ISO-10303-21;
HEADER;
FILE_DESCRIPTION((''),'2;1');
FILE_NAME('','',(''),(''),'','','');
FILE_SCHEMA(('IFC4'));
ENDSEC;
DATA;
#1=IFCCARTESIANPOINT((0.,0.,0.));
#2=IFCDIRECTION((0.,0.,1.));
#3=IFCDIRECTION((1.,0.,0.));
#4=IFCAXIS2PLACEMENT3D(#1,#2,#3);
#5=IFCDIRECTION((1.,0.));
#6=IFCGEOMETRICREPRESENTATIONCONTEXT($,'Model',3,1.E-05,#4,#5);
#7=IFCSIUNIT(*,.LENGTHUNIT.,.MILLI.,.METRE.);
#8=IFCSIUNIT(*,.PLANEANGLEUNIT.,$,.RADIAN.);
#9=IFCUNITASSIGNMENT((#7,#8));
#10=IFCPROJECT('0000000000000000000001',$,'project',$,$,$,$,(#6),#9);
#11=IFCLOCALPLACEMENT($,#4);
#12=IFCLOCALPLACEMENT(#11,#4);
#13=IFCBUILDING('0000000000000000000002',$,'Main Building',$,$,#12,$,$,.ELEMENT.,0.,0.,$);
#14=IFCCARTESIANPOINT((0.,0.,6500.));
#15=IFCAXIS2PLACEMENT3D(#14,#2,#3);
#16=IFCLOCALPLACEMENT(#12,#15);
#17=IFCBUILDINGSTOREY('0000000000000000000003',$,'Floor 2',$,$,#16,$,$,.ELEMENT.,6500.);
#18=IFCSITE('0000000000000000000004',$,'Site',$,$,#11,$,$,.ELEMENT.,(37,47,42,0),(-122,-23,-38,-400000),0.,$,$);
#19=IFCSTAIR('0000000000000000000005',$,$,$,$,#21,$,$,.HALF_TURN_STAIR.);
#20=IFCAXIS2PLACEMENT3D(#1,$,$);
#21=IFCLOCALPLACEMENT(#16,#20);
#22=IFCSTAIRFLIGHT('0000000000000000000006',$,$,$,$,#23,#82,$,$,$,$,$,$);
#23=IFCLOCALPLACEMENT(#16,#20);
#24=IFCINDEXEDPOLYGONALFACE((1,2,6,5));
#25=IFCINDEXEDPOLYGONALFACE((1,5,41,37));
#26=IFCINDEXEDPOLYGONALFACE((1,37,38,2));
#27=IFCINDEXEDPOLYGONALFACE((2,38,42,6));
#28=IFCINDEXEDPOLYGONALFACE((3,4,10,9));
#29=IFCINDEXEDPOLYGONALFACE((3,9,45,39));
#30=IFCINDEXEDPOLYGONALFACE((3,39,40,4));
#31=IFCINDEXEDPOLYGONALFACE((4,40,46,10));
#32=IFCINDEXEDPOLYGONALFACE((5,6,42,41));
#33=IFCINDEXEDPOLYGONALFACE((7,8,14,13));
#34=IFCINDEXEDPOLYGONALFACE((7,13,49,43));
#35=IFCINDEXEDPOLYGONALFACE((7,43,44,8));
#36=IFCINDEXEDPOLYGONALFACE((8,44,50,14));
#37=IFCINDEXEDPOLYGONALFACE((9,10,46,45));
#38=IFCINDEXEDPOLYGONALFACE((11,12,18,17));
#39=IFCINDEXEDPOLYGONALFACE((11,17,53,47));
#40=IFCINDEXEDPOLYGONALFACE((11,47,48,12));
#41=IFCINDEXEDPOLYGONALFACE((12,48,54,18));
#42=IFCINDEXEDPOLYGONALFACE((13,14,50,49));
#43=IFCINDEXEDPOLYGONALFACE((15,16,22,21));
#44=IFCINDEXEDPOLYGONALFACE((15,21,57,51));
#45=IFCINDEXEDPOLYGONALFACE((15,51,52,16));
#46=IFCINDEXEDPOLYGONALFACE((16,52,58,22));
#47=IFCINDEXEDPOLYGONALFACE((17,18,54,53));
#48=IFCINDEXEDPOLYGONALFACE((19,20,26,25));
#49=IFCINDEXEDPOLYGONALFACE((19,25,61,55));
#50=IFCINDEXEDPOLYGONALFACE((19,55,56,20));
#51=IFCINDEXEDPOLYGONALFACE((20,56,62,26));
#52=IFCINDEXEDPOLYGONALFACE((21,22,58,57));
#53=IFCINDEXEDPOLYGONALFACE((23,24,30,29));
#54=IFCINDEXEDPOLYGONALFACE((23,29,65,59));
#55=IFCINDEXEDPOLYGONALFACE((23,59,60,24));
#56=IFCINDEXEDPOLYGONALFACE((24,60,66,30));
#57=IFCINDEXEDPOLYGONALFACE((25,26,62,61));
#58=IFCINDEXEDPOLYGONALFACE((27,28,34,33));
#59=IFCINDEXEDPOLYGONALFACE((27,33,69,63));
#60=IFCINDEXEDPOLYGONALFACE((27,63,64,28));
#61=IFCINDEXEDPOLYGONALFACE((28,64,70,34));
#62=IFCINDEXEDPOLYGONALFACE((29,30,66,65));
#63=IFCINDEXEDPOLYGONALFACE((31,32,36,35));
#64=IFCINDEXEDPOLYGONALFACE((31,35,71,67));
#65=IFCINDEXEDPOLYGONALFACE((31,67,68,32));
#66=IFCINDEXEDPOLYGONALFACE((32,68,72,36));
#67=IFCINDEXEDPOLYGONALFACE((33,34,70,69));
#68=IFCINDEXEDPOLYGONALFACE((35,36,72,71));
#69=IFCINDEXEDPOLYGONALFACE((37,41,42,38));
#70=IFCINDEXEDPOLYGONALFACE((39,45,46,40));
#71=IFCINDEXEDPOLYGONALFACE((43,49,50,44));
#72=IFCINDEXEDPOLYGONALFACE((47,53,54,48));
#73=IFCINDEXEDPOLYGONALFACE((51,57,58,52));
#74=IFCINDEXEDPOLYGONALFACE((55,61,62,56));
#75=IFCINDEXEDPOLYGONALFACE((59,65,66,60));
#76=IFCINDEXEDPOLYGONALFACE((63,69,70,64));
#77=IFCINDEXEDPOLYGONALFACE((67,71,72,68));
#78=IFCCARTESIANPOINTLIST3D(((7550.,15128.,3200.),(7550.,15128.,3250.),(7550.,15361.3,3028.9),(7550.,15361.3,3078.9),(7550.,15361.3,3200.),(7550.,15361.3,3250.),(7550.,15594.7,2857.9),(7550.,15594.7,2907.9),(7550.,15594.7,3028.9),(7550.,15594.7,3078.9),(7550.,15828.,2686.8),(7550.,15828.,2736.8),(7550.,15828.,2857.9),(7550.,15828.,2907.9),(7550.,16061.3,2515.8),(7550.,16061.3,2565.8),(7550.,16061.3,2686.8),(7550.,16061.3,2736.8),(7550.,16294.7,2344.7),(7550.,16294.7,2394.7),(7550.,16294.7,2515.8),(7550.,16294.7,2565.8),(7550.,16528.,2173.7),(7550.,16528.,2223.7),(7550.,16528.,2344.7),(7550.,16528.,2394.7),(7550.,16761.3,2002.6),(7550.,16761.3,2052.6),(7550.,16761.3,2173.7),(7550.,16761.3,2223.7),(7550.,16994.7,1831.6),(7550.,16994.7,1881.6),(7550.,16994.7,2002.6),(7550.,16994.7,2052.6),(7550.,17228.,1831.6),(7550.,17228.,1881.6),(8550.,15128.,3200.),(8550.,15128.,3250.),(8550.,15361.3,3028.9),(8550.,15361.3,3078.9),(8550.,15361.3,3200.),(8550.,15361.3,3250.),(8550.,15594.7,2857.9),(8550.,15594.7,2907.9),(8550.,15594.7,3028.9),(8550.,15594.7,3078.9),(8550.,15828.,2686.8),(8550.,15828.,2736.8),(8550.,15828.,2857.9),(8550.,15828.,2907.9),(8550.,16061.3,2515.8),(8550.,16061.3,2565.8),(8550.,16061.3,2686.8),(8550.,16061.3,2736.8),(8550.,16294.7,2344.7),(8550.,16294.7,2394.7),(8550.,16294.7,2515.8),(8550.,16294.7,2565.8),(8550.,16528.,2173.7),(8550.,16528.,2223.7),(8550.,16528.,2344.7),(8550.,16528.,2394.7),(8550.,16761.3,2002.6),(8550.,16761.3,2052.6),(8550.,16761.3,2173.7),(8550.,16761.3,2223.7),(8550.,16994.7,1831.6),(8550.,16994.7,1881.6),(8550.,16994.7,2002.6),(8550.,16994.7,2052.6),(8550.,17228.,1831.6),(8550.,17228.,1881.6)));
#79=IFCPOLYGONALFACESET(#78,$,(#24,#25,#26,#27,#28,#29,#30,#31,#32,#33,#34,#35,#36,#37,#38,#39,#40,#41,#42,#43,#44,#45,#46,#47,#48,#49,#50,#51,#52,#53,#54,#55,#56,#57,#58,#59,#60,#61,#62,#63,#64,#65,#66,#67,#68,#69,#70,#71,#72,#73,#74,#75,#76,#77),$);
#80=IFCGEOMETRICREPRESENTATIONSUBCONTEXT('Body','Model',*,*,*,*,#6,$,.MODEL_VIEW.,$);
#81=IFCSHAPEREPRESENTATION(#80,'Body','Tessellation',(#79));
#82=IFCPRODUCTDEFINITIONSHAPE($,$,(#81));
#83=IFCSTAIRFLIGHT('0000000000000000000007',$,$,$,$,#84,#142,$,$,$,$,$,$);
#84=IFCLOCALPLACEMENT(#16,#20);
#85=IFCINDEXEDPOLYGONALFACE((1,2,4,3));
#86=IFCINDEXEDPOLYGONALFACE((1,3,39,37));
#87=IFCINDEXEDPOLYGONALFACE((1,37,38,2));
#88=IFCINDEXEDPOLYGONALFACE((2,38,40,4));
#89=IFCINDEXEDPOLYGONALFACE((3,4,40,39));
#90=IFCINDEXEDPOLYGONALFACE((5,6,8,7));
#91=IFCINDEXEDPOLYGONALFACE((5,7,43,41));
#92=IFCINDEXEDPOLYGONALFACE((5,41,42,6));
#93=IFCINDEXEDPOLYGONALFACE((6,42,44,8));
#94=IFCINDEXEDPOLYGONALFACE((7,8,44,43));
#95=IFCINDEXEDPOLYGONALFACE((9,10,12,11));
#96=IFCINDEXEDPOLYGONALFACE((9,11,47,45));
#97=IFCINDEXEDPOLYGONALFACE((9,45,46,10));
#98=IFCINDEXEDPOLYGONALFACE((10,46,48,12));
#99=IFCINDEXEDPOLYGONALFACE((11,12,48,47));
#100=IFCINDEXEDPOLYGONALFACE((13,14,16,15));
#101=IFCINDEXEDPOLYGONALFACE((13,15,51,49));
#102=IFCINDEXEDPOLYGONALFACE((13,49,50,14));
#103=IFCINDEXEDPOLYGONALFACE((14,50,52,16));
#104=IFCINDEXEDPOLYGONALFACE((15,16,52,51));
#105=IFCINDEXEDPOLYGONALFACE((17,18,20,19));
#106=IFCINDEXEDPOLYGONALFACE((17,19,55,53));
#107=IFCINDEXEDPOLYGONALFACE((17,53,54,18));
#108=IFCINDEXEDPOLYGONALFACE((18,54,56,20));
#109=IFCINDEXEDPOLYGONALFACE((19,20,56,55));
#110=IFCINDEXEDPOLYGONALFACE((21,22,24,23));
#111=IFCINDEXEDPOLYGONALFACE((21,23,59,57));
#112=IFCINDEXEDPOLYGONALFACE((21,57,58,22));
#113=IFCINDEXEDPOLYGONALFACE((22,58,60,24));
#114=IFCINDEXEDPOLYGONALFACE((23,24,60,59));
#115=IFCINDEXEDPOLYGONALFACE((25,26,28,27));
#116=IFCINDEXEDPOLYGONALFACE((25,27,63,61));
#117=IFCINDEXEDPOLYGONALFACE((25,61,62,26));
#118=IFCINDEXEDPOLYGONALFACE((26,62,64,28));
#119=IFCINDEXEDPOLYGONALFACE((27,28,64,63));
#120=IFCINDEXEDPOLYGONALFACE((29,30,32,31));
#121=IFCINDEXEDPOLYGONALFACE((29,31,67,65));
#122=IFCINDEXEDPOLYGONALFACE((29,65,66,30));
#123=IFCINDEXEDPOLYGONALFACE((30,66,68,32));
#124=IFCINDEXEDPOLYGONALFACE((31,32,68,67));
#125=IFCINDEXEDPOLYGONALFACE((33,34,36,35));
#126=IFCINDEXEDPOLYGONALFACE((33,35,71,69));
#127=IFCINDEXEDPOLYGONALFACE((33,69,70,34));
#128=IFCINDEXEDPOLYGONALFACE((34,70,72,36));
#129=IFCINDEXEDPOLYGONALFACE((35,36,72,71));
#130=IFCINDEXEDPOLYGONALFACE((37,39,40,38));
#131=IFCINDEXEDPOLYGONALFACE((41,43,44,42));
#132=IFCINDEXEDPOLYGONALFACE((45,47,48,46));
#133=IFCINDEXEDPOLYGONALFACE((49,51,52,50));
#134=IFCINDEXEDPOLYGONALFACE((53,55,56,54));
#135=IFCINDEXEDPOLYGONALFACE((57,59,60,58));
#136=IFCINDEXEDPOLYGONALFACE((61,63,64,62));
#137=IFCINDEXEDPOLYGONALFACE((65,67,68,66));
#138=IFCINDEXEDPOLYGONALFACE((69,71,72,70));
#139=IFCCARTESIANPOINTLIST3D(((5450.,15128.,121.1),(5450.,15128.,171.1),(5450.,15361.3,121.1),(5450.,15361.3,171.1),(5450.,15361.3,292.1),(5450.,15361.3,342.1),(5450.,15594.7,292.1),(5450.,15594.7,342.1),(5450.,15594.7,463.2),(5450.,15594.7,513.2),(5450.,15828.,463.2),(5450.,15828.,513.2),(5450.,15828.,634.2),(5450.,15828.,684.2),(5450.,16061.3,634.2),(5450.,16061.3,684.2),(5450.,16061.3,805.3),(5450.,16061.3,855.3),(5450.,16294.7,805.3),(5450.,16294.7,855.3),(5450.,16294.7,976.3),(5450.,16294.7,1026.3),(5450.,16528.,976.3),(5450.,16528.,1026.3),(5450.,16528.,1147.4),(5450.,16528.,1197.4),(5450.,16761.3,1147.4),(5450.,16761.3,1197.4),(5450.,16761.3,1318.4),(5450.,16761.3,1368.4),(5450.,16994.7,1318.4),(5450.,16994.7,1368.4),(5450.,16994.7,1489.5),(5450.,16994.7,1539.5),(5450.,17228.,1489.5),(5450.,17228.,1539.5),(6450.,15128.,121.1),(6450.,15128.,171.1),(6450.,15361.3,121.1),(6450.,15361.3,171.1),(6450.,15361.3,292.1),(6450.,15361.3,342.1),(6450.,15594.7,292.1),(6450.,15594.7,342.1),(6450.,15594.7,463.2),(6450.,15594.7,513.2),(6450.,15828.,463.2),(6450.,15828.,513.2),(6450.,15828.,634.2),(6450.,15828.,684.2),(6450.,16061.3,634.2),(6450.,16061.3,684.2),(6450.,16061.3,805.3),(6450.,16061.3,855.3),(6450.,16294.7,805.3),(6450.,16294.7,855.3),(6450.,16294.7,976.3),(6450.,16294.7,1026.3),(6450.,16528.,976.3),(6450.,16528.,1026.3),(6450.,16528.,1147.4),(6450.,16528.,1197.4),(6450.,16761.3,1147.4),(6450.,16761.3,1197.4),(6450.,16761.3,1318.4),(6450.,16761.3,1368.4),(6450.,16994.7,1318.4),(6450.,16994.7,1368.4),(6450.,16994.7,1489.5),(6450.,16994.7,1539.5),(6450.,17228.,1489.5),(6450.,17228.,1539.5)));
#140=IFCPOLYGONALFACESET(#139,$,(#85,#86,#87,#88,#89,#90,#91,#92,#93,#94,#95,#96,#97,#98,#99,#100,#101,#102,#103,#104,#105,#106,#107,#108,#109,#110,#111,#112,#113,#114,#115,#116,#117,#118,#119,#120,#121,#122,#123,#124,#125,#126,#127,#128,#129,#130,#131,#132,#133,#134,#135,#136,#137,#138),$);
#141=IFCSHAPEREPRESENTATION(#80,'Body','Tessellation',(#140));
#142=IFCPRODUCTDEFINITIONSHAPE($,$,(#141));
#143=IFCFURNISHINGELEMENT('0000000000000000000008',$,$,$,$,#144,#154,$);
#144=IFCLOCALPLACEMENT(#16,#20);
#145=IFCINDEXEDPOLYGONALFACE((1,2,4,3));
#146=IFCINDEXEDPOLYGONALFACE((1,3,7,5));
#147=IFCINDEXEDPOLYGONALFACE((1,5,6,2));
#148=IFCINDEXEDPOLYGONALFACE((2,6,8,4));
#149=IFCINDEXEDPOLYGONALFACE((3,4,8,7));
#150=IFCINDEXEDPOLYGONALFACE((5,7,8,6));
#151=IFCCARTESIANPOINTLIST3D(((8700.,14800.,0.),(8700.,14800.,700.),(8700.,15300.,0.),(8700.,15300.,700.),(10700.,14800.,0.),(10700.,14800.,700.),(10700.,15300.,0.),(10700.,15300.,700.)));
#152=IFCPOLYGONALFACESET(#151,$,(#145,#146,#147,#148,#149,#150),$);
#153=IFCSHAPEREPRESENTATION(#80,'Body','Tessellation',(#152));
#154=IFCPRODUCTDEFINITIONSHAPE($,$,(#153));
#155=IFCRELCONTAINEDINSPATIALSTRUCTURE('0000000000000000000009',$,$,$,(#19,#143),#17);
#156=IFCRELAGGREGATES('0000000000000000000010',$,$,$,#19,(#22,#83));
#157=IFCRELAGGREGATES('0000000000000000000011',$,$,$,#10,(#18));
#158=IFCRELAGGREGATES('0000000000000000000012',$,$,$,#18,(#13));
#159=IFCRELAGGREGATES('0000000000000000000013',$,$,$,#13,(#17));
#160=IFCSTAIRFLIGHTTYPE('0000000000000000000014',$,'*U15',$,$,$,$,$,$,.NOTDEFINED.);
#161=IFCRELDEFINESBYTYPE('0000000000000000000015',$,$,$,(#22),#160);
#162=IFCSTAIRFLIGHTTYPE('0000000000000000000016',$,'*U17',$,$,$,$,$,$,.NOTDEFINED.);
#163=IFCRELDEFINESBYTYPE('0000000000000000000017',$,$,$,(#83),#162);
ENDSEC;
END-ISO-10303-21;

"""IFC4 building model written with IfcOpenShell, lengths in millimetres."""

from ifc_helpers import new_model, si_unit, direction, frame, frame_2d, origin_with_axes, origin_2d_with_axis, place, context, subcontext, project, spatial, rectangle, extrude, source, transform, mapped, type_object, type_shapes, element, aggregate, save


model = new_model("IFC4")

# Units and contexts
model_context = context("Model", 3, precision=1e-05, world=origin_with_axes(), true_north=direction((1.0, 0.0)))
body_context = subcontext(model_context, "Body", "Model", "MODEL_VIEW")
ifc_project = project(units=[si_unit("LENGTHUNIT", "METRE", prefix="MILLI"), si_unit("PLANEANGLEUNIT", "RADIAN")], contexts=[model_context])

# Site, building, storey
site_placement = place(None, origin_with_axes())
site = spatial("IfcSite", under=ifc_project, at=site_placement, Name="Site", CompositionType="ELEMENT", RefLatitude=(37, 47, 42, 0), RefLongitude=(-122, -23, -38, -400000), RefElevation=0.0)
building_placement = place(site_placement, origin_with_axes())
building = spatial("IfcBuilding", under=site, at=building_placement, Name="Main Building", CompositionType="ELEMENT", ElevationOfRefHeight=0.0, ElevationOfTerrain=0.0)
storey_placement = place(building_placement, frame((0.0, 0.0, 6500.0), z_axis=(0.0, 0.0, 1.0), x_axis=(1.0, 0.0, 0.0)))
storey = spatial("IfcBuildingStorey", under=building, at=storey_placement, Name="Floor 2", CompositionType="ELEMENT", Elevation=6500.0)

# Stair, stair flights
stair_placement = place(storey_placement, frame((8550.0, 15128.0, 3250.0), z_axis=(0.0, 0.0, 1.0), x_axis=(0.0, 1.0, 0.0)))
stair = element("IfcStair", 1, at=stair_placement, inside=storey, PredefinedType="HALF_TURN_STAIR")
stair_flight_type_1 = type_object("IfcStairFlightType", Name="*U15", PredefinedType="NOTDEFINED")
shared_shape_1 = source(origin_with_axes(), body_context, "Body", "SweptSolid", [
    extrude(rectangle(XDim=1000.0, YDim=233.3, at=frame_2d((0.0, 0.0), x_axis=(0.0, 1.0))), frame((116.7, 500.0, -50.0), z_axis=(0.0, 0.0, 1.0), x_axis=(1.0, 0.0, 0.0)), (0.0, 0.0, 1.0), 50.0),
])
shared_shape_2 = source(origin_with_axes(), body_context, "Body", "MappedRepresentation", [
    mapped(shared_shape_1, transform((0.0, 0.0, 0.0), x_axis=(1.0, 0.0, 0.0), y_axis=(0.0, 1.0, 0.0), z_axis=(0.0, 0.0, 1.0), scale=1.0)),
    mapped(shared_shape_1, transform((233.3, 0.0, -171.1), x_axis=(1.0, 0.0, 0.0), y_axis=(0.0, 1.0, 0.0), z_axis=(0.0, 0.0, 1.0), scale=1.0)),
    mapped(shared_shape_1, transform((466.7, 0.0, -342.1), x_axis=(1.0, 0.0, 0.0), y_axis=(0.0, 1.0, 0.0), z_axis=(0.0, 0.0, 1.0), scale=1.0)),
    mapped(shared_shape_1, transform((700.0, 0.0, -513.2), x_axis=(1.0, 0.0, 0.0), y_axis=(0.0, 1.0, 0.0), z_axis=(0.0, 0.0, 1.0), scale=1.0)),
    mapped(shared_shape_1, transform((933.3, 0.0, -684.2), x_axis=(1.0, 0.0, 0.0), y_axis=(0.0, 1.0, 0.0), z_axis=(0.0, 0.0, 1.0), scale=1.0)),
    mapped(shared_shape_1, transform((1166.7, 0.0, -855.3), x_axis=(1.0, 0.0, 0.0), y_axis=(0.0, 1.0, 0.0), z_axis=(0.0, 0.0, 1.0), scale=1.0)),
    mapped(shared_shape_1, transform((1400.0, 0.0, -1026.3), x_axis=(1.0, 0.0, 0.0), y_axis=(0.0, 1.0, 0.0), z_axis=(0.0, 0.0, 1.0), scale=1.0)),
    mapped(shared_shape_1, transform((1633.3, 0.0, -1197.4), x_axis=(1.0, 0.0, 0.0), y_axis=(0.0, 1.0, 0.0), z_axis=(0.0, 0.0, 1.0), scale=1.0)),
    mapped(shared_shape_1, transform((1866.7, 0.0, -1368.4), x_axis=(1.0, 0.0, 0.0), y_axis=(0.0, 1.0, 0.0), z_axis=(0.0, 0.0, 1.0), scale=1.0)),
])
type_shapes(stair_flight_type_1, [shared_shape_2])
stair_flight_1_placement = place(stair_placement, origin_with_axes())
stair_flight_1 = element("IfcStairFlight", 2, at=stair_flight_1_placement, type_object=stair_flight_type_1, context=body_context, shape_type="MappedRepresentation", body=[
    mapped(shared_shape_2, transform((0.0, 0.0, 0.0), x_axis=(1.0, 0.0, 0.0), y_axis=(0.0, 1.0, 0.0), z_axis=(0.0, 0.0, 1.0), scale=1.0)),
])
stair_flight_type_2 = type_object("IfcStairFlightType", Name="*U17", PredefinedType="NOTDEFINED")
shared_shape_3 = source(origin_with_axes(), body_context, "Body", "SweptSolid", [
    extrude(rectangle(XDim=1000.0, YDim=233.3, at=frame_2d((0.0, 0.0), x_axis=(0.0, 1.0))), frame((1983.3, 2600.0, -1760.5), z_axis=(0.0, 0.0, 1.0), x_axis=(1.0, 0.0, 0.0)), (0.0, 0.0, 1.0), 50.0),
])
shared_shape_4 = source(origin_with_axes(), body_context, "Body", "MappedRepresentation", [
    mapped(shared_shape_3, transform((0.0, 0.0, 0.0), x_axis=(1.0, 0.0, 0.0), y_axis=(0.0, 1.0, 0.0), z_axis=(0.0, 0.0, 1.0), scale=1.0)),
    mapped(shared_shape_3, transform((-233.3, 0.0, -171.1), x_axis=(1.0, 0.0, 0.0), y_axis=(0.0, 1.0, 0.0), z_axis=(0.0, 0.0, 1.0), scale=1.0)),
    mapped(shared_shape_3, transform((-466.7, 0.0, -342.1), x_axis=(1.0, 0.0, 0.0), y_axis=(0.0, 1.0, 0.0), z_axis=(0.0, 0.0, 1.0), scale=1.0)),
    mapped(shared_shape_3, transform((-700.0, 0.0, -513.2), x_axis=(1.0, 0.0, 0.0), y_axis=(0.0, 1.0, 0.0), z_axis=(0.0, 0.0, 1.0), scale=1.0)),
    mapped(shared_shape_3, transform((-933.3, 0.0, -684.2), x_axis=(1.0, 0.0, 0.0), y_axis=(0.0, 1.0, 0.0), z_axis=(0.0, 0.0, 1.0), scale=1.0)),
    mapped(shared_shape_3, transform((-1166.7, 0.0, -855.3), x_axis=(1.0, 0.0, 0.0), y_axis=(0.0, 1.0, 0.0), z_axis=(0.0, 0.0, 1.0), scale=1.0)),
    mapped(shared_shape_3, transform((-1400.0, 0.0, -1026.3), x_axis=(1.0, 0.0, 0.0), y_axis=(0.0, 1.0, 0.0), z_axis=(0.0, 0.0, 1.0), scale=1.0)),
    mapped(shared_shape_3, transform((-1633.3, 0.0, -1197.4), x_axis=(1.0, 0.0, 0.0), y_axis=(0.0, 1.0, 0.0), z_axis=(0.0, 0.0, 1.0), scale=1.0)),
    mapped(shared_shape_3, transform((-1866.7, 0.0, -1368.4), x_axis=(1.0, 0.0, 0.0), y_axis=(0.0, 1.0, 0.0), z_axis=(0.0, 0.0, 1.0), scale=1.0)),
])
type_shapes(stair_flight_type_2, [shared_shape_4])
stair_flight_2_placement = place(stair_placement, origin_with_axes())
stair_flight_2 = element("IfcStairFlight", 3, at=stair_flight_2_placement, type_object=stair_flight_type_2, context=body_context, shape_type="MappedRepresentation", body=[
    mapped(shared_shape_4, transform((0.0, 0.0, 0.0), x_axis=(1.0, 0.0, 0.0), y_axis=(0.0, 1.0, 0.0), z_axis=(0.0, 0.0, 1.0), scale=1.0)),
])

# Furnishing element
furnishing_placement = place(storey_placement, frame((8700.0, 14800.0, 0.0), z_axis=(0.0, 0.0, 1.0), x_axis=(1.0, 0.0, 0.0)))
element("IfcFurnishingElement", 4, at=furnishing_placement, inside=storey, context=body_context, shape_type="SweptSolid", body=[
    extrude(rectangle(XDim=2000.0, YDim=500.0, at=origin_2d_with_axis()), frame((1000.0, 250.0, 0.0), z_axis=(0.0, 0.0, 1.0), x_axis=(1.0, 0.0, 0.0)), (0.0, 0.0, 1.0), 700.0),
])

aggregate(stair, [stair_flight_1, stair_flight_2])

save(model, "model.ifc")
